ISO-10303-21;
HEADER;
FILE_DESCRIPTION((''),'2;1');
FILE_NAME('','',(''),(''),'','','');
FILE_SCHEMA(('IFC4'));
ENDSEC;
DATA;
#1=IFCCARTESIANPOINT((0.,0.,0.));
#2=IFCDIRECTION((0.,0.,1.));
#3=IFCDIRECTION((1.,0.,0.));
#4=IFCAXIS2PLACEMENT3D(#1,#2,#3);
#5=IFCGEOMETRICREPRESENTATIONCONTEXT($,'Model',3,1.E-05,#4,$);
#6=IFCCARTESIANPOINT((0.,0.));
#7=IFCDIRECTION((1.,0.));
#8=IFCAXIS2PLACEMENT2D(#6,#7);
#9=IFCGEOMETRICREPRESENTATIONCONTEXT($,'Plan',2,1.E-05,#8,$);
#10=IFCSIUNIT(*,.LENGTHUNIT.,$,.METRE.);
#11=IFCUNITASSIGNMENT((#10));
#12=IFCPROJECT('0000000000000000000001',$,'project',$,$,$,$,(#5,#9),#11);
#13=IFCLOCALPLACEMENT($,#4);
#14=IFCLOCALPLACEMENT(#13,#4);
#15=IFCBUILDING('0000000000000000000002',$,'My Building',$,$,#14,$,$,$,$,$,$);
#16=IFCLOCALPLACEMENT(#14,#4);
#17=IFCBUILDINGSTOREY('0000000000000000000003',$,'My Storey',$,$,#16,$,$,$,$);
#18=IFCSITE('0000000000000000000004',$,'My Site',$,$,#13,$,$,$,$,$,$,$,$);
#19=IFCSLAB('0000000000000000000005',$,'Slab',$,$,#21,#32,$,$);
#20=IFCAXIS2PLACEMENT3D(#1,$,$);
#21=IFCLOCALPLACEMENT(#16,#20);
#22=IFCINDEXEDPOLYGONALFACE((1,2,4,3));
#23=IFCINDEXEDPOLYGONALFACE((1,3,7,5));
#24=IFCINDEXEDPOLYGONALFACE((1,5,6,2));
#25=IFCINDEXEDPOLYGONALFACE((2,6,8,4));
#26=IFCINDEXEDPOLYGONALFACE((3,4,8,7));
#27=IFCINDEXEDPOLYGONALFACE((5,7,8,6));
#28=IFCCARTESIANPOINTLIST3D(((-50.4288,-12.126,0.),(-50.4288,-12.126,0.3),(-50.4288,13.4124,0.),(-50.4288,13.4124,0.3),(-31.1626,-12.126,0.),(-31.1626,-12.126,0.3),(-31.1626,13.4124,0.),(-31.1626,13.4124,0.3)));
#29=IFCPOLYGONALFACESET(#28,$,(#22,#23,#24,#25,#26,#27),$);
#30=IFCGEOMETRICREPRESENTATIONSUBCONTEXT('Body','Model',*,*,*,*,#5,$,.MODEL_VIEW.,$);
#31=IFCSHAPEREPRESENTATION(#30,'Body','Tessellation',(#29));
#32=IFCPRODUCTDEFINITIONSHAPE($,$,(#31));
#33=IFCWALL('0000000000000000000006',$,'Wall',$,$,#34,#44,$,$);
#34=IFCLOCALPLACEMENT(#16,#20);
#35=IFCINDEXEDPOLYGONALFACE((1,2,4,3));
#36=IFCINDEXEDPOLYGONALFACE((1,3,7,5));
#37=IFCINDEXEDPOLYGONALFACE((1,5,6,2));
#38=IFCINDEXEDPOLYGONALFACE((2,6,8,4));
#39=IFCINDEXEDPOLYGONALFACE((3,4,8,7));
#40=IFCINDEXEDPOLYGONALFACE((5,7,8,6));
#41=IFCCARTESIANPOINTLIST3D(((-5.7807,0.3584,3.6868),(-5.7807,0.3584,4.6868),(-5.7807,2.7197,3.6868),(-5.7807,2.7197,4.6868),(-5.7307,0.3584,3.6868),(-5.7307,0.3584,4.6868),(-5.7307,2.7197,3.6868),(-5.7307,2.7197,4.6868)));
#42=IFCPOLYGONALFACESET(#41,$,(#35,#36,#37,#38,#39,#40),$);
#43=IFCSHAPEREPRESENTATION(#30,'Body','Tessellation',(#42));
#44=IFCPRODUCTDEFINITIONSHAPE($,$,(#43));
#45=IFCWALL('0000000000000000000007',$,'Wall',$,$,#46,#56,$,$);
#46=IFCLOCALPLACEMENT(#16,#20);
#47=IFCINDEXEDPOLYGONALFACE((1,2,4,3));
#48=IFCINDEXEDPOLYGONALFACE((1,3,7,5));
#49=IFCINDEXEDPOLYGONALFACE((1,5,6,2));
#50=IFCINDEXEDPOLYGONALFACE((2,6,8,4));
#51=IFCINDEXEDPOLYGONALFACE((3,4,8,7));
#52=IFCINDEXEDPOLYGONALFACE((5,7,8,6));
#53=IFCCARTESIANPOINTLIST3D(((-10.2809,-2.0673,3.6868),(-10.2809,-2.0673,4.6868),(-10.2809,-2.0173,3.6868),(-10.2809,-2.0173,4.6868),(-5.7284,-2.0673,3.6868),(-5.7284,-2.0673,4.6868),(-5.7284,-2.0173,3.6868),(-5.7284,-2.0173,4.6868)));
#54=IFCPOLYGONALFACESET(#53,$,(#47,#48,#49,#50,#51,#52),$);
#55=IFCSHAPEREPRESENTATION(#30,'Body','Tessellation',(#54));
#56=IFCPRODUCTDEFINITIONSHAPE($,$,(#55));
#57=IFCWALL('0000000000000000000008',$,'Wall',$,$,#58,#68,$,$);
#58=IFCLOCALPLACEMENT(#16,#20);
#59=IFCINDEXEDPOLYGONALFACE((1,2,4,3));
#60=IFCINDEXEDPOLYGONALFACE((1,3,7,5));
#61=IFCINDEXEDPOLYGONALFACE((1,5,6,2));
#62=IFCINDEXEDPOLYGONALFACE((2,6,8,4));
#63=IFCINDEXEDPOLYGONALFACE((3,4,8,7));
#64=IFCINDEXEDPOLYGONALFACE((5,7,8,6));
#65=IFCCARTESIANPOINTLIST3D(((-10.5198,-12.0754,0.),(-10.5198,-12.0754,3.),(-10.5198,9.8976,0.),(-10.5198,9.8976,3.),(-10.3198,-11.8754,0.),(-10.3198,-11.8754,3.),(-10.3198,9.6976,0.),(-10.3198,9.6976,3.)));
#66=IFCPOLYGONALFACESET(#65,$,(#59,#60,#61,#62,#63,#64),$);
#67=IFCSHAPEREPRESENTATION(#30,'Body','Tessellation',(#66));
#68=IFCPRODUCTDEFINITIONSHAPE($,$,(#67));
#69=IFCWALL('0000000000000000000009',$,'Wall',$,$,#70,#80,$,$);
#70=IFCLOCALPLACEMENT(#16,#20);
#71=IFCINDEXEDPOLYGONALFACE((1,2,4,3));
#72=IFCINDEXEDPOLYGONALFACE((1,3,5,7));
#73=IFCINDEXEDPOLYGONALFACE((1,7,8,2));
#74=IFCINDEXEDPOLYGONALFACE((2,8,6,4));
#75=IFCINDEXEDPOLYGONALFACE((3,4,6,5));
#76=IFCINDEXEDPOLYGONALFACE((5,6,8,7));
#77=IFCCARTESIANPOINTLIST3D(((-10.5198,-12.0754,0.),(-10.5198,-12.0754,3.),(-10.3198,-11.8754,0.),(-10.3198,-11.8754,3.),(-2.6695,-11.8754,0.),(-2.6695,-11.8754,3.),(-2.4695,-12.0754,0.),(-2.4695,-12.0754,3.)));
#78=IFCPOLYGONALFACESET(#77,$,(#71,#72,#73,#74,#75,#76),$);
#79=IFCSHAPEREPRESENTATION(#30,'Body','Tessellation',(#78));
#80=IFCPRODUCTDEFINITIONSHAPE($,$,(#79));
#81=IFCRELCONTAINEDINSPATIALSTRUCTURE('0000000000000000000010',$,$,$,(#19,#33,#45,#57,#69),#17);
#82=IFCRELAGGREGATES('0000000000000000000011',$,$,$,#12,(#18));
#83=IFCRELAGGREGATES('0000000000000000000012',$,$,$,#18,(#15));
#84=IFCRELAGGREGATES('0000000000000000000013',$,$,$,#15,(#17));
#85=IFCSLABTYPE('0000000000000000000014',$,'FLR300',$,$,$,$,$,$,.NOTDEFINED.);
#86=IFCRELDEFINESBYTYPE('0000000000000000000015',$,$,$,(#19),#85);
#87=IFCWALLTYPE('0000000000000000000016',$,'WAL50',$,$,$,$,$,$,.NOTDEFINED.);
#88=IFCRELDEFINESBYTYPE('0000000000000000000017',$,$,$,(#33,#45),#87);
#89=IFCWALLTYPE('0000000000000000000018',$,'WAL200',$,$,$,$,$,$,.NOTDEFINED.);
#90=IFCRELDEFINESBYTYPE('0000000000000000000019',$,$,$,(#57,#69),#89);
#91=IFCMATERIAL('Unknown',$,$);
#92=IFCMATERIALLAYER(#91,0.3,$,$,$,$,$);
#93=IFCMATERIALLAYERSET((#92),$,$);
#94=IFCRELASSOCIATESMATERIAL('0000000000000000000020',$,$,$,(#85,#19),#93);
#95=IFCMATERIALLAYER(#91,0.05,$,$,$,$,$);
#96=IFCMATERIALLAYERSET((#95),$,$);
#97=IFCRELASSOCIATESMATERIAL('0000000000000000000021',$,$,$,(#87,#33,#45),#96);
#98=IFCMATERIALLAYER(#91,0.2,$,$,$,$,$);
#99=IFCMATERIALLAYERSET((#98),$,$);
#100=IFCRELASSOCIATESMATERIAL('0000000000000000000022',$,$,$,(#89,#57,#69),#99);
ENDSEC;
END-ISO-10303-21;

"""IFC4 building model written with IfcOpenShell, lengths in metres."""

from ifc_helpers import new_model, si_unit, frame, origin_with_axes, origin_2d_with_axis, place, context, subcontext, project, spatial, line, indexed_curve, outline, extrude, material, layer, layer_set, layer_usage, type_object, element, save


model = new_model("IFC4")

# Units and contexts
model_context = context("Model", 3, precision=1e-05, world=origin_with_axes())
plan_context = context("Plan", 2, precision=1e-05, world=origin_2d_with_axis())
body_context_1 = subcontext(model_context, "Body", "Model", "MODEL_VIEW")
ifc_project = project(units=[si_unit("LENGTHUNIT", "METRE")], contexts=[model_context, plan_context])

# Site, building, storey
site_placement = place(None, origin_with_axes())
site = spatial("IfcSite", under=ifc_project, at=site_placement, Name="My Site")
building_placement = place(site_placement, origin_with_axes())
building = spatial("IfcBuilding", under=site, at=building_placement, Name="My Building")
storey_placement = place(building_placement, origin_with_axes())
storey = spatial("IfcBuildingStorey", under=building, at=storey_placement, Name="My Storey")

# Slab
ifc_material = material(Name="Unknown")
ifc_layer_1 = layer(ifc_material, 0.3)
ifc_layer_set_1 = layer_set([ifc_layer_1])
ifc_layer_usage_1 = layer_usage(ifc_layer_set_1, "AXIS3", "POSITIVE", 0.0)
slab_type = type_object("IfcSlabType", Name="FLR300", PredefinedType="NOTDEFINED", material=ifc_layer_set_1)
slab_placement = place(storey_placement, frame((-31.1626, -12.126, 0.0), z_axis=(0.0, 0.0, 1.0), x_axis=(1.0, 0.0, 0.0)))
element("IfcSlab", 1, at=slab_placement, inside=storey, type_object=slab_type, material=ifc_layer_usage_1, Name="Slab", context=body_context_1, shape_type="SweptSolid", body=[
    extrude(outline(indexed_curve([(0.0, 0.0), (-19.2663, 0.0), (-19.2663, 25.5384), (0.0, 25.5384), (0.0, 0.0)])), None, (0.0, 0.0, 1.0), 0.3),
])

# Walls
ifc_layer_2 = layer(ifc_material, 0.05)
ifc_layer_set_2 = layer_set([ifc_layer_2])
ifc_layer_usage_2 = layer_usage(ifc_layer_set_2, "AXIS2", "POSITIVE", 0.0)
wall_type_1 = type_object("IfcWallType", Name="WAL50", PredefinedType="NOTDEFINED", material=ifc_layer_set_2)
wall_1_placement = place(storey_placement, frame((-5.7807, 2.7197, 3.6868), z_axis=(0.0, 0.0, 1.0), x_axis=(0.0, -1.0, 0.0)))
element("IfcWall", 2, at=wall_1_placement, inside=storey, type_object=wall_type_1, material=ifc_layer_usage_2, Name="Wall", context=body_context_1, shape_type="SweptSolid", body=[
    extrude(outline(indexed_curve([(0.0, 0.0), (0.0, 0.05), (2.3612, 0.05), (2.3612, 0.0)], segments=[line(1, 2, 3, 4, 1)])), origin_with_axes(), (0.0, 0.0, 1.0), 1.0),
])
ifc_layer_usage_3 = layer_usage(ifc_layer_set_2, "AXIS2", "POSITIVE", 0.0)
wall_2_placement = place(storey_placement, frame((-10.2809, -2.0673, 3.6868), z_axis=(0.0, 0.0, 1.0), x_axis=(1.0, 0.0, 0.0)))
element("IfcWall", 3, at=wall_2_placement, inside=storey, type_object=wall_type_1, material=ifc_layer_usage_3, Name="Wall", context=body_context_1, shape_type="SweptSolid", body=[
    extrude(outline(indexed_curve([(0.0, 0.0), (0.0, 0.05), (4.5525, 0.05), (4.5525, 0.0)], segments=[line(1, 2, 3, 4, 1)])), origin_with_axes(), (0.0, 0.0, 1.0), 1.0),
])
ifc_layer_3 = layer(ifc_material, 0.2)
ifc_layer_set_3 = layer_set([ifc_layer_3])
ifc_layer_usage_4 = layer_usage(ifc_layer_set_3, "AXIS2", "POSITIVE", 0.0)
wall_type_2 = type_object("IfcWallType", Name="WAL200", PredefinedType="NOTDEFINED", material=ifc_layer_set_3)
wall_3_placement = place(storey_placement, frame((-10.5198, 9.8976, 0.0), z_axis=(0.0, 0.0, 1.0), x_axis=(0.0, -1.0, 0.0)))
element("IfcWall", 4, at=wall_3_placement, inside=storey, type_object=wall_type_2, material=ifc_layer_usage_4, Name="Wall", context=body_context_1, shape_type="SweptSolid", body=[
    extrude(outline(indexed_curve([(0.0, 0.0), (0.2, 0.2), (21.773, 0.2), (21.973, 0.0)], segments=[line(1, 2, 3, 4, 1)])), origin_with_axes(), (0.0, 0.0, 1.0), 3.0),
])
ifc_layer_usage_5 = layer_usage(ifc_layer_set_3, "AXIS2", "POSITIVE", 0.0)
wall_4_placement = place(storey_placement, frame((-10.5198, -12.0754, 0.0), z_axis=(0.0, 0.0, 1.0), x_axis=(1.0, 0.0, 0.0)))
element("IfcWall", 5, at=wall_4_placement, inside=storey, type_object=wall_type_2, material=ifc_layer_usage_5, Name="Wall", context=body_context_1, shape_type="SweptSolid", body=[
    extrude(outline(indexed_curve([(0.0, 0.0), (0.2, 0.2), (7.8503, 0.2), (8.0503, 0.0)], segments=[line(1, 2, 3, 4, 1)])), origin_with_axes(), (0.0, 0.0, 1.0), 3.0),
])

save(model, "model.ifc")
